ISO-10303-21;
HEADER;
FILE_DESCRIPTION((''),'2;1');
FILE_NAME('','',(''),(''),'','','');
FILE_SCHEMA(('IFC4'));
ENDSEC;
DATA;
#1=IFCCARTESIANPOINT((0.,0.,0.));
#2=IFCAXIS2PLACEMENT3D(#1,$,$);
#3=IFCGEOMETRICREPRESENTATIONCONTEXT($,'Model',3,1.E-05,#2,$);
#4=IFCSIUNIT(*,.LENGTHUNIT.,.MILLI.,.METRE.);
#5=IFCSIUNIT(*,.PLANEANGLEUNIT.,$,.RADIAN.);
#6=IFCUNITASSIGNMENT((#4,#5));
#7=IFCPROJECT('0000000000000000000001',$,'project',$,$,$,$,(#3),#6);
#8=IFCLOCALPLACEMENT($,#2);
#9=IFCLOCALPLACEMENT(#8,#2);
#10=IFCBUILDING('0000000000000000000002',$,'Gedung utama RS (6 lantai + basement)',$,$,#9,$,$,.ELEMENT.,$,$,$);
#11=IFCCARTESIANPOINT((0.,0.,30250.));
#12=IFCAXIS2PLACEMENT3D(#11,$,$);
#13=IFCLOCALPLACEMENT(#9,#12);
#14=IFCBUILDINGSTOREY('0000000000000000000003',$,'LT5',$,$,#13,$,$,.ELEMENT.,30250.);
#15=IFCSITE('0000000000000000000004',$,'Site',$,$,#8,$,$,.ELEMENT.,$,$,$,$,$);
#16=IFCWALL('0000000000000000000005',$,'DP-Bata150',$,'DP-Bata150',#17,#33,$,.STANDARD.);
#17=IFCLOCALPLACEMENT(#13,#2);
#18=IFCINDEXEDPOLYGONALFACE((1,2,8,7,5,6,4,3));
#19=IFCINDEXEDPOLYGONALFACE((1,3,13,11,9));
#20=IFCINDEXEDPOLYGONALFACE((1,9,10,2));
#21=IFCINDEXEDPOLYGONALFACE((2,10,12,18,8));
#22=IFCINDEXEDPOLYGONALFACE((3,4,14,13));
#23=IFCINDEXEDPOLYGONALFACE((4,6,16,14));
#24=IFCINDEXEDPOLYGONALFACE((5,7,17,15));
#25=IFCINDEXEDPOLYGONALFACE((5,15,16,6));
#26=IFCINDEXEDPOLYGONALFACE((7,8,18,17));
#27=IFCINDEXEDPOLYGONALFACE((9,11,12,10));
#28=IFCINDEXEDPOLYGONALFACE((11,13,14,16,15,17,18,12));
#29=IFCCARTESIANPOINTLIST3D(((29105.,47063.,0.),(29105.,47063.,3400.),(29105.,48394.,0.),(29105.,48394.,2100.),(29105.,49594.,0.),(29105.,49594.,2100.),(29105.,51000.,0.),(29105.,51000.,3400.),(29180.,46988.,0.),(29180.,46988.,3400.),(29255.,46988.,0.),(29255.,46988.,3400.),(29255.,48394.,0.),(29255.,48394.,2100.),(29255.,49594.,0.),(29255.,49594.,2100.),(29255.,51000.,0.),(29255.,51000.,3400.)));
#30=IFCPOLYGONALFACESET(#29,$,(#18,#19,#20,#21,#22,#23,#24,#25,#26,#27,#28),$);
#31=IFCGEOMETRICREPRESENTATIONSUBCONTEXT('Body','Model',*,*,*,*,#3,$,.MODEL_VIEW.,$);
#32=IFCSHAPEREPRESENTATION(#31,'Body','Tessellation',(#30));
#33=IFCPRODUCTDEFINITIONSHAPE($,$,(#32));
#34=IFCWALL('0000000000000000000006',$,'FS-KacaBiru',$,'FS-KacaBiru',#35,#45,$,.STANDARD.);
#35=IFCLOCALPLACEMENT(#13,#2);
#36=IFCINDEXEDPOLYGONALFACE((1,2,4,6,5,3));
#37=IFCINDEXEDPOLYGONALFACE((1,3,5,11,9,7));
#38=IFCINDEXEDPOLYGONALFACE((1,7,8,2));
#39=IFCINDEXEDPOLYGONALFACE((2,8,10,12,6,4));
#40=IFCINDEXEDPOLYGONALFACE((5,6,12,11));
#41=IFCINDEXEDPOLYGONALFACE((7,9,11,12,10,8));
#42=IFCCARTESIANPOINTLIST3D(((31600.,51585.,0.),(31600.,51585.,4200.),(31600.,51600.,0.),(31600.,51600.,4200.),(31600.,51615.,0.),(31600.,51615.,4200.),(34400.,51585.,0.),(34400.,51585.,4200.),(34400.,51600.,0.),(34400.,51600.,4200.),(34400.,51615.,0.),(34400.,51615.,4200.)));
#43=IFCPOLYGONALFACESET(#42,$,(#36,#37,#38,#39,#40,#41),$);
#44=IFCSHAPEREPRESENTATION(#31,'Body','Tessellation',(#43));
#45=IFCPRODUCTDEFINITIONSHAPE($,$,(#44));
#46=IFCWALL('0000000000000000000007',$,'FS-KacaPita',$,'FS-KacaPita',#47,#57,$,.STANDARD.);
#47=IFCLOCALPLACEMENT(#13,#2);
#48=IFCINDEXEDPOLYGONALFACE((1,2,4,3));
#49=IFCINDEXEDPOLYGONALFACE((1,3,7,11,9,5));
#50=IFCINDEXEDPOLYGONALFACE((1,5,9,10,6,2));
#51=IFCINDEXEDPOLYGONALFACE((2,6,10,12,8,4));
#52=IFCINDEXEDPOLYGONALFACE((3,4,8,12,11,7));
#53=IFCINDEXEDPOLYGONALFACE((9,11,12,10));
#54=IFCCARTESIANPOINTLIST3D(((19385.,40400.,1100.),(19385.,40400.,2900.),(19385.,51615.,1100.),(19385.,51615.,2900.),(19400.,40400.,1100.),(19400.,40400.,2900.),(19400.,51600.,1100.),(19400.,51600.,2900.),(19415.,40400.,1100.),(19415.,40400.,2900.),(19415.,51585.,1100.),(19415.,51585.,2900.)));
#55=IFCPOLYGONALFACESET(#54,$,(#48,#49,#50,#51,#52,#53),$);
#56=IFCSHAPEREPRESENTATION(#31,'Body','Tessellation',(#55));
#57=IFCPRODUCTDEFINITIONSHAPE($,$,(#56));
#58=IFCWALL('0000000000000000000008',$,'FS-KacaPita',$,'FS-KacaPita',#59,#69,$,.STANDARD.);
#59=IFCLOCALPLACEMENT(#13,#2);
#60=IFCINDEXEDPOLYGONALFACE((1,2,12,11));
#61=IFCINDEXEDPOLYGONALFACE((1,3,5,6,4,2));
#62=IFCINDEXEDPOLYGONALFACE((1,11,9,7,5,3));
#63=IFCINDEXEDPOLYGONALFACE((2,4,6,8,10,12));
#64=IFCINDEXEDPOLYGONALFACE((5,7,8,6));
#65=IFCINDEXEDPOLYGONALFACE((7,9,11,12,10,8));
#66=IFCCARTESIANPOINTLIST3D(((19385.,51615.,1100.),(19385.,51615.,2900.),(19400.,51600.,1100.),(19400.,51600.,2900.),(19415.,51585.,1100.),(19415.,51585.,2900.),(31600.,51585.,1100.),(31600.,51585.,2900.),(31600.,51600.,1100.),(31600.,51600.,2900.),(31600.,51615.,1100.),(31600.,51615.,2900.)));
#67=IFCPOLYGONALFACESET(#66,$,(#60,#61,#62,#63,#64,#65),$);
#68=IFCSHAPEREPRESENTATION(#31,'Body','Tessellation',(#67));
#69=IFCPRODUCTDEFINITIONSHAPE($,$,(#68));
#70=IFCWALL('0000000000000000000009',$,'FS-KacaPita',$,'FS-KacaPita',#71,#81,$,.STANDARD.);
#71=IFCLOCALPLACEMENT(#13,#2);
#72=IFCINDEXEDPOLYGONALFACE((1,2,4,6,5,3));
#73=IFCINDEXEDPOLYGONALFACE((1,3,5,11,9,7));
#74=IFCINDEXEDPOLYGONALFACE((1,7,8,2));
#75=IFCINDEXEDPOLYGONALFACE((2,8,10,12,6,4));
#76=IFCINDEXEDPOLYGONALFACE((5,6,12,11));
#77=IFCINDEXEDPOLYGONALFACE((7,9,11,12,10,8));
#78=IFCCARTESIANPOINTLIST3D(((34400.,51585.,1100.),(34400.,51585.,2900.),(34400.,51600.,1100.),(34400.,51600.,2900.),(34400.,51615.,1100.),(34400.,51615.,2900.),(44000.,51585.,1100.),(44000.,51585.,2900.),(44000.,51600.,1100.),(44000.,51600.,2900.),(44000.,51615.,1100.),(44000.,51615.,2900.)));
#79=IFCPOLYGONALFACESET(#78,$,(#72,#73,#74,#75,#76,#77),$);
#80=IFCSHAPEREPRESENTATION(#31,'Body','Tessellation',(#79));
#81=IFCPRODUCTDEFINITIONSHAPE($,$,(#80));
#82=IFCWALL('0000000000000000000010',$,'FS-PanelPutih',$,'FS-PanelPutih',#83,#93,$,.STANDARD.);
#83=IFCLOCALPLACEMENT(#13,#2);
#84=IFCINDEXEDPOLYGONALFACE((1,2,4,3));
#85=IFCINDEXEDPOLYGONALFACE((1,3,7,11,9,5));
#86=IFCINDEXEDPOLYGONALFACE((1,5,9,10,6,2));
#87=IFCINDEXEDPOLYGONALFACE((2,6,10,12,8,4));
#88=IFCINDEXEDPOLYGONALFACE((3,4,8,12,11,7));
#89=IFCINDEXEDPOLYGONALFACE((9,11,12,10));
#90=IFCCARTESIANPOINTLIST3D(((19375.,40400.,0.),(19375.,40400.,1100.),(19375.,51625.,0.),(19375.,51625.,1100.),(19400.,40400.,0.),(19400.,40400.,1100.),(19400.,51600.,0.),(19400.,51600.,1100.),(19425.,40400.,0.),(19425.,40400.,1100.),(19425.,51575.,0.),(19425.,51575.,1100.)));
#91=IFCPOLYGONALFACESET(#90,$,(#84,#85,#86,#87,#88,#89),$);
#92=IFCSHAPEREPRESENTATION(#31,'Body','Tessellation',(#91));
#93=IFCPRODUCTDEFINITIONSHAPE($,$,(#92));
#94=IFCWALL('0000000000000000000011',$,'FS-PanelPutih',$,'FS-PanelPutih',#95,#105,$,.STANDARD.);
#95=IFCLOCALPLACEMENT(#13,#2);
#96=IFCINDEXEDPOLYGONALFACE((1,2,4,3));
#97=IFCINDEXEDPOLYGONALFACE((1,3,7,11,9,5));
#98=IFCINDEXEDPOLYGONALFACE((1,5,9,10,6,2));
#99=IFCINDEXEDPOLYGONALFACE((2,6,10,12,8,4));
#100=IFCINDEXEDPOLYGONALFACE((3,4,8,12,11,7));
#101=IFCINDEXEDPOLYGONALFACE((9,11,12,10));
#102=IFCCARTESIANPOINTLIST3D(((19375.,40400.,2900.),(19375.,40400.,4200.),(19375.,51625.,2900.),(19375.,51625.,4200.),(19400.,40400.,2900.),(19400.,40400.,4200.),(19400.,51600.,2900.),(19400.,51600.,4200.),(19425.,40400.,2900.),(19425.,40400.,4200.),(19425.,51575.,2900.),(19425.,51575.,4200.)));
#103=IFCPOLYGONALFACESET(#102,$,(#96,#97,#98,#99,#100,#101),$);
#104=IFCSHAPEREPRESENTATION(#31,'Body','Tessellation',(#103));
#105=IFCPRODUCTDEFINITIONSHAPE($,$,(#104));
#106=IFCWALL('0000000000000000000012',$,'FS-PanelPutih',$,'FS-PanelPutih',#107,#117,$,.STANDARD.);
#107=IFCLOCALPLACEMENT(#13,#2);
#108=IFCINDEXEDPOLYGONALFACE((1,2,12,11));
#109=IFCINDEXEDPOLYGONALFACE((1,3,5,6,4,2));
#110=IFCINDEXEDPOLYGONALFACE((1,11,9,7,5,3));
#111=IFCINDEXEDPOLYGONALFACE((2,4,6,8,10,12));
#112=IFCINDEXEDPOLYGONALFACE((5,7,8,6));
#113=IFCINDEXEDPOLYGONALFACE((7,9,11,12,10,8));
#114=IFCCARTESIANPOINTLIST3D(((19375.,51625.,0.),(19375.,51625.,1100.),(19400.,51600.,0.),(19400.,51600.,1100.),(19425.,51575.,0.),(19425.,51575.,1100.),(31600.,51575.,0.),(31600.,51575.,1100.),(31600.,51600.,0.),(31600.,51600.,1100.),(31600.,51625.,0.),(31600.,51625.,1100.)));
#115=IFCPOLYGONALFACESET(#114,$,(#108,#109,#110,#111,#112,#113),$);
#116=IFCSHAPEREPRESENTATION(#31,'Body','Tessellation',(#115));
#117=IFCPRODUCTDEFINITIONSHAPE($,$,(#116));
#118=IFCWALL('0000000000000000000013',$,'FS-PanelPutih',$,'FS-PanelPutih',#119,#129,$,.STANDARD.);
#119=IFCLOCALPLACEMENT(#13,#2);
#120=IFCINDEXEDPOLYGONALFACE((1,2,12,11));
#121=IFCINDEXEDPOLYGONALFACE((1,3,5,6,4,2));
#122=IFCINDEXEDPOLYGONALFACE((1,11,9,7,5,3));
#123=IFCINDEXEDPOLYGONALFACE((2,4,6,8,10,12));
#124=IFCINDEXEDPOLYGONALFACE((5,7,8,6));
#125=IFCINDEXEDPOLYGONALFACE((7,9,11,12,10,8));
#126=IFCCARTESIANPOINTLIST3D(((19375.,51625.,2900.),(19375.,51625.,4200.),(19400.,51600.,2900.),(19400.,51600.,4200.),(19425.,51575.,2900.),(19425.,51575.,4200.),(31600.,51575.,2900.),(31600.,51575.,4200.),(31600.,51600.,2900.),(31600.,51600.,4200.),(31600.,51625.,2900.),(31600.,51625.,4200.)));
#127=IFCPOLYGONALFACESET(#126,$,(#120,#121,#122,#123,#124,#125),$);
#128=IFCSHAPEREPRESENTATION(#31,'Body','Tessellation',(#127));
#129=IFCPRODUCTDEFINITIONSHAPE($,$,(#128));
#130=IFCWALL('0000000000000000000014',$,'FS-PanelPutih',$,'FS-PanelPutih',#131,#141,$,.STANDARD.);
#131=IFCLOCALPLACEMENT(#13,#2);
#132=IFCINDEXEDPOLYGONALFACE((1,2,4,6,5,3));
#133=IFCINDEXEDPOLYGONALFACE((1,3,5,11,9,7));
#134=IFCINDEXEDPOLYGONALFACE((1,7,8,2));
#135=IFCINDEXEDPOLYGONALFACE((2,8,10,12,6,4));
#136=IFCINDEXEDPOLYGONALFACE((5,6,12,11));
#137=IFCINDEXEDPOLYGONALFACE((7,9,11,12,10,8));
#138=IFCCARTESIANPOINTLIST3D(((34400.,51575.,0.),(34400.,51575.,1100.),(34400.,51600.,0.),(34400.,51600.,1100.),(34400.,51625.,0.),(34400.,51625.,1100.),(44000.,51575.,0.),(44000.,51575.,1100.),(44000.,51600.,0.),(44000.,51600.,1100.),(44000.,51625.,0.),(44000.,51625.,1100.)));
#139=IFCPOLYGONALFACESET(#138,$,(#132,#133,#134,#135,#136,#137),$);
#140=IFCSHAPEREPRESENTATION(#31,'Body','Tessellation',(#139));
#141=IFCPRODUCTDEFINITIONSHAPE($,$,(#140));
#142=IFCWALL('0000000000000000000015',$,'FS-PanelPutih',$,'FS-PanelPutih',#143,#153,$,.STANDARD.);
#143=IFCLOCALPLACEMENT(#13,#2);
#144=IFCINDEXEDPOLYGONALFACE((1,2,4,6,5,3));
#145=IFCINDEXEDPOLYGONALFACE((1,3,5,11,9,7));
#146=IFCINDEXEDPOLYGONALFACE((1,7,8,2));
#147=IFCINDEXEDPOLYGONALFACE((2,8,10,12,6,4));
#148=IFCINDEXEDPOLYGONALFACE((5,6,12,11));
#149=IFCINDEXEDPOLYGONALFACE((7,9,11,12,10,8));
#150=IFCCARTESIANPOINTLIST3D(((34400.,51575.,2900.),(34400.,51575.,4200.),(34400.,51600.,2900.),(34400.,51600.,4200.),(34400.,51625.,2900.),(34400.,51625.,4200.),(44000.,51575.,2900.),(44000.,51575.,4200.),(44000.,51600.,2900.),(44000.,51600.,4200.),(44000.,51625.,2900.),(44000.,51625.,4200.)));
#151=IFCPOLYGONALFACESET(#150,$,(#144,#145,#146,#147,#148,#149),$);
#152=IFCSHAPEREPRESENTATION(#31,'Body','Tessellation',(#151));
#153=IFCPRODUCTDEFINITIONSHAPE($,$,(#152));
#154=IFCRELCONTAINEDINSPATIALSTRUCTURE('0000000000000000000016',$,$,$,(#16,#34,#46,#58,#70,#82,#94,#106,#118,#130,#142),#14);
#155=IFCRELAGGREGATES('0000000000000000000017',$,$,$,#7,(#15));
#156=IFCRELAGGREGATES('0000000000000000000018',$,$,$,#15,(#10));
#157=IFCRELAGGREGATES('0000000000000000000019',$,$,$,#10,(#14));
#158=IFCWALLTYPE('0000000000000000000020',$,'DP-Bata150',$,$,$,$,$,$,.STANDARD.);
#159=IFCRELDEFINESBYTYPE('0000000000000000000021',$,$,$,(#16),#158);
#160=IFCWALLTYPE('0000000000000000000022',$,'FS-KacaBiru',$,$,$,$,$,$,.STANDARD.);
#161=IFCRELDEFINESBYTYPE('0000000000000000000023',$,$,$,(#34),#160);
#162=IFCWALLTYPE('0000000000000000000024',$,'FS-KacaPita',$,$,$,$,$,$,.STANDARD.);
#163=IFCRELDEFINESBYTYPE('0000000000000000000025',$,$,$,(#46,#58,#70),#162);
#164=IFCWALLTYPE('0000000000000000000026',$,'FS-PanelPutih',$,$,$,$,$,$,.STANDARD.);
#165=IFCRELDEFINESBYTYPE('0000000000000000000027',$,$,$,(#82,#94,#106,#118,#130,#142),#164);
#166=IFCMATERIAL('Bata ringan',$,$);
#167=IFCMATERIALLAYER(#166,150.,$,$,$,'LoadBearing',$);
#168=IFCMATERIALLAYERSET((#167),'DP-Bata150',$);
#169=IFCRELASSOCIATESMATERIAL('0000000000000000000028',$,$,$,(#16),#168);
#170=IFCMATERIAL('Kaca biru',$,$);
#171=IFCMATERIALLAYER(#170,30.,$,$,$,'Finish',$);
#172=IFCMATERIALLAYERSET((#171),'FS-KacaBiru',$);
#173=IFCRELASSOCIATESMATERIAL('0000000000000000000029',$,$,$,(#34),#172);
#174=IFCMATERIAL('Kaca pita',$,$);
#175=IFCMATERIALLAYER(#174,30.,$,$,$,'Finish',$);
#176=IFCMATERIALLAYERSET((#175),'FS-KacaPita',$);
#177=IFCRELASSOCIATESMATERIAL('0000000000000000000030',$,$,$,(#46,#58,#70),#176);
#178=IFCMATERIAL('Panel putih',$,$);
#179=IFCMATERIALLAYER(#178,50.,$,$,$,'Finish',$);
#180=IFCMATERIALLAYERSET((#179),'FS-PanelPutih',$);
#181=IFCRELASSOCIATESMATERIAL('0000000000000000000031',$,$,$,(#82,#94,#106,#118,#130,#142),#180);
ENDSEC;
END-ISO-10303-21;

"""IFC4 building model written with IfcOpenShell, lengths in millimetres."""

from ifc_helpers import new_model, si_unit, frame, frame_2d, origin, place, context, subcontext, project, spatial, polyline, rectangle, outline, extrude, material, layer, layer_set, layer_usage, type_object, element, save


model = new_model("IFC4")

# Units and contexts
model_context = context("Model", 3, precision=1e-05, world=origin())
body_context = subcontext(model_context, "Body", "Model", "MODEL_VIEW")
ifc_project = project(units=[si_unit("LENGTHUNIT", "METRE", prefix="MILLI"), si_unit("PLANEANGLEUNIT", "RADIAN")], contexts=[model_context])

# Site, building, storey
site_placement = place(None, origin())
site = spatial("IfcSite", under=ifc_project, at=site_placement, Name="Site", CompositionType="ELEMENT")
building_placement = place(site_placement, origin())
building = spatial("IfcBuilding", under=site, at=building_placement, Name="Gedung utama RS (6 lantai + basement)", CompositionType="ELEMENT")
storey_placement = place(building_placement, frame((0.0, 0.0, 30250.0)))
storey = spatial("IfcBuildingStorey", under=building, at=storey_placement, Name="LT5", CompositionType="ELEMENT", Elevation=30250.0)

# Shared definitions
ifc_material_1 = material(Name="Bata ringan")

# Shared definitions
ifc_layer_1 = layer(ifc_material_1, 150.0, Category="LoadBearing")
ifc_layer_set_1 = layer_set([ifc_layer_1], Name="DP-Bata150")
ifc_layer_usage_1 = layer_usage(ifc_layer_set_1, "AXIS2", "NEGATIVE", 75.0)
wall_type_1 = type_object("IfcWallType", Name="DP-Bata150", PredefinedType="STANDARD")

# Wall, opening
wall_1_placement = place(storey_placement, frame((29180.0, 46988.0, 0.0), z_axis=(0.0, 0.0, 1.0), x_axis=(0.0, 1.0, 0.0)))
wall_1 = element("IfcWall", 1, at=wall_1_placement, inside=storey, type_object=wall_type_1, material=ifc_layer_usage_1, Name="DP-Bata150", ObjectType="DP-Bata150", PredefinedType="STANDARD", context=body_context, shape_type="SweptSolid", body=[
    extrude(outline(polyline([(0.0, -75.0), (0.0, 0.0), (75.0, 75.0), (4012.0, 75.0), (4012.0, -75.0), (0.0, -75.0)])), origin(), (0.0, 0.0, 1.0), 3400.0),
])
opening_1_placement = place(wall_1_placement, frame((1406.0, 0.0, 0.0), z_axis=(0.0, 0.0, 1.0), x_axis=(1.0, 0.0, 0.0)))
element("IfcOpeningElement", 2, at=opening_1_placement, cuts=wall_1, PredefinedType="OPENING", context=body_context, shape_type="SweptSolid", body=[
    extrude(rectangle(XDim=1200.0, YDim=170.0, at=frame_2d((600.0, 0.0))), origin(), (0.0, 0.0, 1.0), 2100.0),
])

# Walls
ifc_material_2 = material(Name="Kaca biru")
ifc_layer_2 = layer(ifc_material_2, 30.0, Category="Finish")
ifc_layer_set_2 = layer_set([ifc_layer_2], Name="FS-KacaBiru")
ifc_layer_usage_2 = layer_usage(ifc_layer_set_2, "AXIS2", "NEGATIVE", 15.0)
wall_type_2 = type_object("IfcWallType", Name="FS-KacaBiru", PredefinedType="STANDARD")
wall_2_placement = place(storey_placement, frame((31600.0, 51600.0, 0.0), z_axis=(0.0, 0.0, 1.0), x_axis=(1.0, 0.0, 0.0)))
element("IfcWall", 3, at=wall_2_placement, inside=storey, type_object=wall_type_2, material=ifc_layer_usage_2, Name="FS-KacaBiru", ObjectType="FS-KacaBiru", PredefinedType="STANDARD", context=body_context, shape_type="SweptSolid", body=[
    extrude(outline(polyline([(0.0, -15.0), (0.0, 0.0), (0.0, 15.0), (2800.0, 15.0), (2800.0, 0.0), (2800.0, -15.0), (0.0, -15.0)])), origin(), (0.0, 0.0, 1.0), 4200.0),
])
ifc_material_3 = material(Name="Kaca pita")
ifc_layer_3 = layer(ifc_material_3, 30.0, Category="Finish")
ifc_layer_set_3 = layer_set([ifc_layer_3], Name="FS-KacaPita")
ifc_layer_usage_3 = layer_usage(ifc_layer_set_3, "AXIS2", "NEGATIVE", 15.0)
wall_type_3 = type_object("IfcWallType", Name="FS-KacaPita", PredefinedType="STANDARD")
wall_3_placement = place(storey_placement, frame((19400.0, 40400.0, 1100.0), z_axis=(0.0, 0.0, 1.0), x_axis=(0.0, 1.0, 0.0)))
element("IfcWall", 4, at=wall_3_placement, inside=storey, type_object=wall_type_3, material=ifc_layer_usage_3, Name="FS-KacaPita", ObjectType="FS-KacaPita", PredefinedType="STANDARD", context=body_context, shape_type="SweptSolid", body=[
    extrude(outline(polyline([(0.0, -15.0), (0.0, 0.0), (0.0, 15.0), (11215.0, 15.0), (11200.0, 0.0), (11185.0, -15.0), (0.0, -15.0)])), origin(), (0.0, 0.0, 1.0), 1800.0),
])
wall_4_placement = place(storey_placement, frame((19400.0, 51600.0, 1100.0), z_axis=(0.0, 0.0, 1.0), x_axis=(1.0, 0.0, 0.0)))
element("IfcWall", 5, at=wall_4_placement, inside=storey, type_object=wall_type_3, material=ifc_layer_usage_3, Name="FS-KacaPita", ObjectType="FS-KacaPita", PredefinedType="STANDARD", context=body_context, shape_type="SweptSolid", body=[
    extrude(outline(polyline([(15.0, -15.0), (0.0, 0.0), (-15.0, 15.0), (12200.0, 15.0), (12200.0, 0.0), (12200.0, -15.0), (15.0, -15.0)])), origin(), (0.0, 0.0, 1.0), 1800.0),
])
wall_5_placement = place(storey_placement, frame((34400.0, 51600.0, 1100.0), z_axis=(0.0, 0.0, 1.0), x_axis=(1.0, 0.0, 0.0)))
element("IfcWall", 6, at=wall_5_placement, inside=storey, type_object=wall_type_3, material=ifc_layer_usage_3, Name="FS-KacaPita", ObjectType="FS-KacaPita", PredefinedType="STANDARD", context=body_context, shape_type="SweptSolid", body=[
    extrude(outline(polyline([(0.0, -15.0), (0.0, 0.0), (0.0, 15.0), (9600.0, 15.0), (9600.0, 0.0), (9600.0, -15.0), (0.0, -15.0)])), origin(), (0.0, 0.0, 1.0), 1800.0),
])
ifc_material_4 = material(Name="Panel putih")
ifc_layer_4 = layer(ifc_material_4, 50.0, Category="Finish")
ifc_layer_set_4 = layer_set([ifc_layer_4], Name="FS-PanelPutih")
ifc_layer_usage_4 = layer_usage(ifc_layer_set_4, "AXIS2", "NEGATIVE", 25.0)
wall_type_4 = type_object("IfcWallType", Name="FS-PanelPutih", PredefinedType="STANDARD")
wall_6_placement = place(storey_placement, frame((19400.0, 40400.0, 0.0), z_axis=(0.0, 0.0, 1.0), x_axis=(0.0, 1.0, 0.0)))
element("IfcWall", 7, at=wall_6_placement, inside=storey, type_object=wall_type_4, material=ifc_layer_usage_4, Name="FS-PanelPutih", ObjectType="FS-PanelPutih", PredefinedType="STANDARD", context=body_context, shape_type="SweptSolid", body=[
    extrude(outline(polyline([(0.0, -25.0), (0.0, 0.0), (0.0, 25.0), (11225.0, 25.0), (11200.0, 0.0), (11175.0, -25.0), (0.0, -25.0)])), origin(), (0.0, 0.0, 1.0), 1100.0),
])
wall_7_placement = place(storey_placement, frame((19400.0, 40400.0, 2900.0), z_axis=(0.0, 0.0, 1.0), x_axis=(0.0, 1.0, 0.0)))
element("IfcWall", 8, at=wall_7_placement, inside=storey, type_object=wall_type_4, material=ifc_layer_usage_4, Name="FS-PanelPutih", ObjectType="FS-PanelPutih", PredefinedType="STANDARD", context=body_context, shape_type="SweptSolid", body=[
    extrude(outline(polyline([(0.0, -25.0), (0.0, 0.0), (0.0, 25.0), (11225.0, 25.0), (11200.0, 0.0), (11175.0, -25.0), (0.0, -25.0)])), origin(), (0.0, 0.0, 1.0), 1300.0),
])
wall_8_placement = place(storey_placement, frame((19400.0, 51600.0, 0.0), z_axis=(0.0, 0.0, 1.0), x_axis=(1.0, 0.0, 0.0)))
element("IfcWall", 9, at=wall_8_placement, inside=storey, type_object=wall_type_4, material=ifc_layer_usage_4, Name="FS-PanelPutih", ObjectType="FS-PanelPutih", PredefinedType="STANDARD", context=body_context, shape_type="SweptSolid", body=[
    extrude(outline(polyline([(25.0, -25.0), (0.0, 0.0), (-25.0, 25.0), (12200.0, 25.0), (12200.0, 0.0), (12200.0, -25.0), (25.0, -25.0)])), origin(), (0.0, 0.0, 1.0), 1100.0),
])
wall_9_placement = place(storey_placement, frame((19400.0, 51600.0, 2900.0), z_axis=(0.0, 0.0, 1.0), x_axis=(1.0, 0.0, 0.0)))
element("IfcWall", 10, at=wall_9_placement, inside=storey, type_object=wall_type_4, material=ifc_layer_usage_4, Name="FS-PanelPutih", ObjectType="FS-PanelPutih", PredefinedType="STANDARD", context=body_context, shape_type="SweptSolid", body=[
    extrude(outline(polyline([(25.0, -25.0), (0.0, 0.0), (-25.0, 25.0), (12200.0, 25.0), (12200.0, 0.0), (12200.0, -25.0), (25.0, -25.0)])), origin(), (0.0, 0.0, 1.0), 1300.0),
])
wall_10_placement = place(storey_placement, frame((34400.0, 51600.0, 0.0), z_axis=(0.0, 0.0, 1.0), x_axis=(1.0, 0.0, 0.0)))
element("IfcWall", 11, at=wall_10_placement, inside=storey, type_object=wall_type_4, material=ifc_layer_usage_4, Name="FS-PanelPutih", ObjectType="FS-PanelPutih", PredefinedType="STANDARD", context=body_context, shape_type="SweptSolid", body=[
    extrude(outline(polyline([(0.0, -25.0), (0.0, 0.0), (0.0, 25.0), (9600.0, 25.0), (9600.0, 0.0), (9600.0, -25.0), (0.0, -25.0)])), origin(), (0.0, 0.0, 1.0), 1100.0),
])
wall_11_placement = place(storey_placement, frame((34400.0, 51600.0, 2900.0), z_axis=(0.0, 0.0, 1.0), x_axis=(1.0, 0.0, 0.0)))
element("IfcWall", 12, at=wall_11_placement, inside=storey, type_object=wall_type_4, material=ifc_layer_usage_4, Name="FS-PanelPutih", ObjectType="FS-PanelPutih", PredefinedType="STANDARD", context=body_context, shape_type="SweptSolid", body=[
    extrude(outline(polyline([(0.0, -25.0), (0.0, 0.0), (0.0, 25.0), (9600.0, 25.0), (9600.0, 0.0), (9600.0, -25.0), (0.0, -25.0)])), origin(), (0.0, 0.0, 1.0), 1300.0),
])

save(model, "model.ifc")
